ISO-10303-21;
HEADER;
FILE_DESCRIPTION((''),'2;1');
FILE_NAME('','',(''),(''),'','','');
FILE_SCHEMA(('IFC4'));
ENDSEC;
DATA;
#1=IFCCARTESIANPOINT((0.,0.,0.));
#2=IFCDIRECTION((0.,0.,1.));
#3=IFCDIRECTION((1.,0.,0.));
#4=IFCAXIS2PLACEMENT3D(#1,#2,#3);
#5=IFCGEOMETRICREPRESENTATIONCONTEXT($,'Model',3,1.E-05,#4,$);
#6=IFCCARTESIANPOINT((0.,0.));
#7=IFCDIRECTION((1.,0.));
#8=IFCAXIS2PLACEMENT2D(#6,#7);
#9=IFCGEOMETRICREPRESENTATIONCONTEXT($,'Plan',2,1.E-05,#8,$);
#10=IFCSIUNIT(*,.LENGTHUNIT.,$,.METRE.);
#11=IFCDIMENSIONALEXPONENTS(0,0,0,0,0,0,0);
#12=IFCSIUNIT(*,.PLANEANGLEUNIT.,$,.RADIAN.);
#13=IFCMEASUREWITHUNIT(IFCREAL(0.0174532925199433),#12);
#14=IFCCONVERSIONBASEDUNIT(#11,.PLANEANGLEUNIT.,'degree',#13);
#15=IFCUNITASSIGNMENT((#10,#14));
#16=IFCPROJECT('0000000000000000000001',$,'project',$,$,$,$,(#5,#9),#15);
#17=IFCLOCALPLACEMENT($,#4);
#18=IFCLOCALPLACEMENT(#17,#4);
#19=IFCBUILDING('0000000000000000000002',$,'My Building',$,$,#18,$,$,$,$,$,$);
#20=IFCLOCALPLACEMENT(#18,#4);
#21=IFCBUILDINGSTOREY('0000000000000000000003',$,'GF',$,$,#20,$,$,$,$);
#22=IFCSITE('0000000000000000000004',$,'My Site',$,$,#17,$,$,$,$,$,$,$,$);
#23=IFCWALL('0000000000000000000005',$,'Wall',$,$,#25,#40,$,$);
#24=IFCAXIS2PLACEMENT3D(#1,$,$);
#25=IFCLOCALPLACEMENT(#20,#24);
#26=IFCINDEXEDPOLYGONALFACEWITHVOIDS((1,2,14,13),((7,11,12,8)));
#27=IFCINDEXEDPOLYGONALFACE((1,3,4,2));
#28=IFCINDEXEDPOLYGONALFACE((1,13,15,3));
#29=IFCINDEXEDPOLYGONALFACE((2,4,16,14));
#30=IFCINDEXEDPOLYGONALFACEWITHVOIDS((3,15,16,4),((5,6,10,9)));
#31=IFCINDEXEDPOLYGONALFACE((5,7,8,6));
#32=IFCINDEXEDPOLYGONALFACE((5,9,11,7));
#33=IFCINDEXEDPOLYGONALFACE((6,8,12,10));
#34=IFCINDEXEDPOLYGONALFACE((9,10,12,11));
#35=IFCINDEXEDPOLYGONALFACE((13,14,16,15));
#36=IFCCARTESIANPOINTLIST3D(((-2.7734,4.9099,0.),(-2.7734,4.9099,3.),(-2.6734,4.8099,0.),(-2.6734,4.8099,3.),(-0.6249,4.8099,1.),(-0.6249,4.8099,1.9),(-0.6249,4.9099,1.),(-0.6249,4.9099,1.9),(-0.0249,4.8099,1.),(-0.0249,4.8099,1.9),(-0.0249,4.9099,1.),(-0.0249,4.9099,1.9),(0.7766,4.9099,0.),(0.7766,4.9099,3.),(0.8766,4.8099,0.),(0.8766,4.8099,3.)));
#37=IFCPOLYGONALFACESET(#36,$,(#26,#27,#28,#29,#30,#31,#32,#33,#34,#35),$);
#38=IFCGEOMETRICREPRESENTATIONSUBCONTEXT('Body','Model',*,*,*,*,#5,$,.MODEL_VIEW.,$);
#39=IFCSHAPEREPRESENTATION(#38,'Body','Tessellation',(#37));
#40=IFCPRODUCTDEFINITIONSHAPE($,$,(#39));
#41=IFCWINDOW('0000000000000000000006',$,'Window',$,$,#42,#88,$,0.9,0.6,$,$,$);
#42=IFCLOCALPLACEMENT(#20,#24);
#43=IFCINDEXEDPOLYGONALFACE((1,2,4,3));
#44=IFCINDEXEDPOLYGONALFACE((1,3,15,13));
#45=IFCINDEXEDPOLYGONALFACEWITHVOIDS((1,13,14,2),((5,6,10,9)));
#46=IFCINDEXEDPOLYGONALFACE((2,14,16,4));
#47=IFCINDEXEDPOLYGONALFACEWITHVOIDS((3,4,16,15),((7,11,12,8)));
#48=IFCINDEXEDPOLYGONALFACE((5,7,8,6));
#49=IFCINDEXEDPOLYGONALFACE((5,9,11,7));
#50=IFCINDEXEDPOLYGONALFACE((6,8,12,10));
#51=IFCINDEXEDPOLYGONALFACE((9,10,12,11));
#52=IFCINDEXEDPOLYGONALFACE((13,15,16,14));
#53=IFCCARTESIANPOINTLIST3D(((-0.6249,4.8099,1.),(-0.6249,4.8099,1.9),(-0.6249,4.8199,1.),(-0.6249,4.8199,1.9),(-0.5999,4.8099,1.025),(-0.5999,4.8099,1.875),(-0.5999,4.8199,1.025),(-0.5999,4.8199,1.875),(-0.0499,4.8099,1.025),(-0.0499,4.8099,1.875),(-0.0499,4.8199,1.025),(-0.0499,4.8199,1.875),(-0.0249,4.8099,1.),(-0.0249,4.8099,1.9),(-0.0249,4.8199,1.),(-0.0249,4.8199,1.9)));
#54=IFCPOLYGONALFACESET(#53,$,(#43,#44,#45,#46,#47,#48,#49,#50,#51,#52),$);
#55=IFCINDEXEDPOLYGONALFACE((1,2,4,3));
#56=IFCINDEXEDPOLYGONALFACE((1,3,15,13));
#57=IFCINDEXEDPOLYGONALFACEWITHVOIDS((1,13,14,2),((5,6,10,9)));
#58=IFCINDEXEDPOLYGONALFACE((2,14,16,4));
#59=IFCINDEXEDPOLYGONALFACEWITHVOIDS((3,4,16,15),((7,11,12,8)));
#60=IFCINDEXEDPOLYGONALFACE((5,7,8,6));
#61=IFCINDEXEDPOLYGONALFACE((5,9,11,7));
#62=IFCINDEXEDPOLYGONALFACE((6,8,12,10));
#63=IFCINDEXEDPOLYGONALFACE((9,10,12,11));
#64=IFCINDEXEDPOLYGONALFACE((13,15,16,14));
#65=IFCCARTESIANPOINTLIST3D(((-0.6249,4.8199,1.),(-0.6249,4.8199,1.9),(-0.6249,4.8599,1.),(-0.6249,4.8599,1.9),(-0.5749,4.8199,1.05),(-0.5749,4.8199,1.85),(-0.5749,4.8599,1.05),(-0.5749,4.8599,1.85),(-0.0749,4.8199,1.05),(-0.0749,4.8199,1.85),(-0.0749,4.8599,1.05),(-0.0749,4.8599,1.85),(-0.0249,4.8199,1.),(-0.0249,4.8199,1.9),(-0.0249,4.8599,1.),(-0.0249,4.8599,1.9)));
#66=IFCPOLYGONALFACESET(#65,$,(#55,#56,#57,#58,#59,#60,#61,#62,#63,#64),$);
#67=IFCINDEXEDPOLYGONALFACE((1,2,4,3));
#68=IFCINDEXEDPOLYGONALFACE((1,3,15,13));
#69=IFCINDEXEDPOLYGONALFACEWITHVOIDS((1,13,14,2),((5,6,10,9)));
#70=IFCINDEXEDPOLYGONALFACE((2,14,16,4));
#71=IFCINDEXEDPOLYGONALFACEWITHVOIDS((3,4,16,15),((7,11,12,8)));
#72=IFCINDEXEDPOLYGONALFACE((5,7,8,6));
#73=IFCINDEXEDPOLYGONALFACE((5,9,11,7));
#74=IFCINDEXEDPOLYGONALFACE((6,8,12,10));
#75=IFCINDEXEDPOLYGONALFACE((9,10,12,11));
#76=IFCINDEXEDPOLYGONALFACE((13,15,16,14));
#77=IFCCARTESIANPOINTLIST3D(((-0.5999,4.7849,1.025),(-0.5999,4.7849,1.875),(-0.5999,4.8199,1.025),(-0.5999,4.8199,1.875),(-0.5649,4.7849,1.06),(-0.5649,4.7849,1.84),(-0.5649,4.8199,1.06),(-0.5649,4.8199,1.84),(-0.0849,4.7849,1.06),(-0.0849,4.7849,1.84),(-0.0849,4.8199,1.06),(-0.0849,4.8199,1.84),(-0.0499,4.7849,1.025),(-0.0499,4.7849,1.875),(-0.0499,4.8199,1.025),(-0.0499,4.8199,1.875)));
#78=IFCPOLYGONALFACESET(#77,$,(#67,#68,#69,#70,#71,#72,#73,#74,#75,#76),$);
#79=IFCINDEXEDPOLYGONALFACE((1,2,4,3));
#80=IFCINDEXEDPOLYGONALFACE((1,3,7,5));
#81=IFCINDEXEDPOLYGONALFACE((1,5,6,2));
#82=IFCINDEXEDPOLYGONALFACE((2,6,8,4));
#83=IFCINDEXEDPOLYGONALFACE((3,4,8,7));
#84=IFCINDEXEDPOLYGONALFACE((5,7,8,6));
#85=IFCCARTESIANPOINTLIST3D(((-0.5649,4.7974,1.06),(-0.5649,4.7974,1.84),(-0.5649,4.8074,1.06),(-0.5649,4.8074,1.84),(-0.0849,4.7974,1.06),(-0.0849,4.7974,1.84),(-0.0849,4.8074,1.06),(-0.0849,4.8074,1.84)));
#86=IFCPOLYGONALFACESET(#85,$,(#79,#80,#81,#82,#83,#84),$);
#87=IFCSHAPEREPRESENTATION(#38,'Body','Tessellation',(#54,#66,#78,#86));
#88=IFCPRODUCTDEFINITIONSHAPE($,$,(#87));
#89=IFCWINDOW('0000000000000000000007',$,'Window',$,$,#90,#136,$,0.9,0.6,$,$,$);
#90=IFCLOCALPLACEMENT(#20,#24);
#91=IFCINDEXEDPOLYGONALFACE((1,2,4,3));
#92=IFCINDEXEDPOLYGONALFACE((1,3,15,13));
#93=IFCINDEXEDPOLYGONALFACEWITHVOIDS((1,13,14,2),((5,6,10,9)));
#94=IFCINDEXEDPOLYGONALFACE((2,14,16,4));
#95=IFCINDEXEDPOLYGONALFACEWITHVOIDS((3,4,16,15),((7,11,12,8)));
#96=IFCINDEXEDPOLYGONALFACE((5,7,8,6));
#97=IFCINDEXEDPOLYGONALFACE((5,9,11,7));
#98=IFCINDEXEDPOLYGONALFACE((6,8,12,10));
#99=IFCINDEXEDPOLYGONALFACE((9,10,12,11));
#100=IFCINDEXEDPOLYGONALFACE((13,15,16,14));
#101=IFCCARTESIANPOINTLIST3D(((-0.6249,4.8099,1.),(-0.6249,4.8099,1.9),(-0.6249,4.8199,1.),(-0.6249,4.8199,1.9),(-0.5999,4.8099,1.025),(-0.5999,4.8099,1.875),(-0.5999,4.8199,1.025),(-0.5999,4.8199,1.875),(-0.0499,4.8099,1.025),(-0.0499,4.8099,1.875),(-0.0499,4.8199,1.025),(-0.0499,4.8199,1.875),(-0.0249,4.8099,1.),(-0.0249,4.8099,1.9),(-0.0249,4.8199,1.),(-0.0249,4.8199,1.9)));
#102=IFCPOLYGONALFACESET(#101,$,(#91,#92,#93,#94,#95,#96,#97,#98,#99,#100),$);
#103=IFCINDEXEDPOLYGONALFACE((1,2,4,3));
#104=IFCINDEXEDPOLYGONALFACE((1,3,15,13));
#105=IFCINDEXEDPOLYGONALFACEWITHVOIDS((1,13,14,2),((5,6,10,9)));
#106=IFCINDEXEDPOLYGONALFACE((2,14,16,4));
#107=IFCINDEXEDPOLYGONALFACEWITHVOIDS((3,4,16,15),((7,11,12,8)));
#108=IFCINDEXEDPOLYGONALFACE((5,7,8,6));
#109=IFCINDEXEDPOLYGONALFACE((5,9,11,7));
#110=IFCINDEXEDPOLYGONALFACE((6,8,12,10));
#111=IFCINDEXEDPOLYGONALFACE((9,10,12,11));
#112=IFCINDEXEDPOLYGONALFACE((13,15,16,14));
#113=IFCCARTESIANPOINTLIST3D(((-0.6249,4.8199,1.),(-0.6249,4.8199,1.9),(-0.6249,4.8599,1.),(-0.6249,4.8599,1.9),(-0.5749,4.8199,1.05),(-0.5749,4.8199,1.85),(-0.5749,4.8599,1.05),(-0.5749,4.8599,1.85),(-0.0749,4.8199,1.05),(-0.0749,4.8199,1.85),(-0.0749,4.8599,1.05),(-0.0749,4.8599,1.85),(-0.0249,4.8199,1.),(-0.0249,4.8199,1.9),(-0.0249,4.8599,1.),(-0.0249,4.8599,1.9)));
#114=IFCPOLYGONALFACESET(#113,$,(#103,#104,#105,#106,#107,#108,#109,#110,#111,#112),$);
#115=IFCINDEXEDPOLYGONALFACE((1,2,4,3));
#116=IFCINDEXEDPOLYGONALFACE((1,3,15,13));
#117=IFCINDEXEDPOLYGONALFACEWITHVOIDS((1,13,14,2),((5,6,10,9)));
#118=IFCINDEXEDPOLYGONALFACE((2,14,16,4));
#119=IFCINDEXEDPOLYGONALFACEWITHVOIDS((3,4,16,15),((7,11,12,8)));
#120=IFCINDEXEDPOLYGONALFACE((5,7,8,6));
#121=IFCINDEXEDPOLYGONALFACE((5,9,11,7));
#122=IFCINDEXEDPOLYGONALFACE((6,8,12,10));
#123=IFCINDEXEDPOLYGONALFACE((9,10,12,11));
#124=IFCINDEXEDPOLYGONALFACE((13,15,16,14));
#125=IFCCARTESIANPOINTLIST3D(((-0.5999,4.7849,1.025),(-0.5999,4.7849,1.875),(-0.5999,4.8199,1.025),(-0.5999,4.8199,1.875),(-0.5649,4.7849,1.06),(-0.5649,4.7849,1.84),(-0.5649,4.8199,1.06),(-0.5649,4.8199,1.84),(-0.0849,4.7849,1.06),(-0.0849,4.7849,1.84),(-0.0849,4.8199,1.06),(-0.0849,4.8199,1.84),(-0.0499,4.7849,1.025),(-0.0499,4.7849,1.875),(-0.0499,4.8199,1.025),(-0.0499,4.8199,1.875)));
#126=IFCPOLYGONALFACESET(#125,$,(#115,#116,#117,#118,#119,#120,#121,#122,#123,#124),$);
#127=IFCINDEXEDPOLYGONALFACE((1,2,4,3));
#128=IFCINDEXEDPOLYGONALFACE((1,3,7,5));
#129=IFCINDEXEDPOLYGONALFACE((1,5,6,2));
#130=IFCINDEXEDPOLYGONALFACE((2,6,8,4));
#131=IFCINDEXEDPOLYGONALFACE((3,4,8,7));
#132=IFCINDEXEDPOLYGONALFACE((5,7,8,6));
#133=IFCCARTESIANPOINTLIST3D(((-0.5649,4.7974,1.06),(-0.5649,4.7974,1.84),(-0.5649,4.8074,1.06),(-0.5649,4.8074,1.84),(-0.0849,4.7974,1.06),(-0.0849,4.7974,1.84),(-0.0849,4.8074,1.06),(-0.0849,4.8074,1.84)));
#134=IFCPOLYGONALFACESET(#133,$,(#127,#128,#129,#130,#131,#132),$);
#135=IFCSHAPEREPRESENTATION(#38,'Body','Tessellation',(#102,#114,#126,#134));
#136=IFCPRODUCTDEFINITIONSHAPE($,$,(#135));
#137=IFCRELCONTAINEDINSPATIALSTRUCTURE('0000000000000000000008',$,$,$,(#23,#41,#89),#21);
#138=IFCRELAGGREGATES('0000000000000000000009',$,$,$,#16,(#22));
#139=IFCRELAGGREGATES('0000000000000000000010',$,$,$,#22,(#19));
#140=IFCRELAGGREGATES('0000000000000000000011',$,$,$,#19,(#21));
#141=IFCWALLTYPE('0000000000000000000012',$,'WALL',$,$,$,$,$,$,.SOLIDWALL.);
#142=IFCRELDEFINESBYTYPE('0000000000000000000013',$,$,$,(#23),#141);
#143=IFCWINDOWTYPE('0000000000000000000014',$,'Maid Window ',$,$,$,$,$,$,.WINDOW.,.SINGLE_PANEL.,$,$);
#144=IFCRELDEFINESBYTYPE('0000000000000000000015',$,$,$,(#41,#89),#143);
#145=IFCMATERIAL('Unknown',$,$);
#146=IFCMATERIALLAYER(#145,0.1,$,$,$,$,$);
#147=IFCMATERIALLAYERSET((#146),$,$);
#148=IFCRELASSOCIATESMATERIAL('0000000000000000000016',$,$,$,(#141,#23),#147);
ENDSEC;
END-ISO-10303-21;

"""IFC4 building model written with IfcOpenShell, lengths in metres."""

from ifc_helpers import new_model, entity, si_unit, converted_unit, frame, origin_with_axes, origin_2d_with_axis, place, context, subcontext, project, spatial, line, indexed_curve, outline, extrude, shape, source, transform, mapped, material, layer, layer_set, layer_usage, type_object, type_shapes, element, fill, save


model = new_model("IFC4")

# Units and contexts
model_context = context("Model", 3, precision=1e-05, world=origin_with_axes())
plan_context = context("Plan", 2, precision=1e-05, world=origin_2d_with_axis())
body_context_1 = subcontext(model_context, "Body", "Model", "MODEL_VIEW")
body_context_2 = subcontext(plan_context, "Body", "Plan", "PLAN_VIEW")
ifc_project = project(units=[si_unit("LENGTHUNIT", "METRE"), converted_unit("PLANEANGLEUNIT", "degree", entity("IfcReal", 0.0174532925199433), si_unit("PLANEANGLEUNIT", "RADIAN"), dimensions=[0, 0, 0, 0, 0, 0, 0])], contexts=[model_context, plan_context])

# Site, building, storey
site_placement = place(None, origin_with_axes())
site = spatial("IfcSite", under=ifc_project, at=site_placement, Name="My Site")
building_placement = place(site_placement, origin_with_axes())
building = spatial("IfcBuilding", under=site, at=building_placement, Name="My Building")
storey_placement = place(building_placement, origin_with_axes())
storey = spatial("IfcBuildingStorey", under=building, at=storey_placement, Name="GF")

# Shared definitions
ifc_material = material(Name="Unknown")

# Shared definitions
ifc_layer = layer(ifc_material, 0.1)
ifc_layer_set = layer_set([ifc_layer])
wall_type = type_object("IfcWallType", Name="WALL", PredefinedType="SOLIDWALL", material=ifc_layer_set)

# Wall, openings, windows
ifc_layer_usage_1 = layer_usage(ifc_layer_set, "AXIS2", "POSITIVE", 0.0)
wall_1_placement = place(storey_placement, frame((0.7766, 4.9099, 0.0), z_axis=(0.0, 0.0, 1.0), x_axis=(-1.0, 0.0, 0.0)))
wall_1 = element("IfcWall", 1, at=wall_1_placement, inside=storey, type_object=wall_type, material=ifc_layer_usage_1, Name="Wall", context=body_context_1, shape_type="SweptSolid", body=[
    extrude(outline(indexed_curve([(0.0, 0.0), (-0.1, 0.1), (3.45, 0.1), (3.55, 0.0)], segments=[line(1, 2, 3, 4, 1)])), origin_with_axes(), (0.0, 0.0, 1.0), 3.0),
])
shared_shape_1 = source(origin_with_axes(), body_context_1, "Body", "SweptSolid", [
    extrude(outline(indexed_curve([(0.0, 0.0), (0.6, 0.0), (0.6, 0.9), (0.0, 0.9)], segments=[line(1, 2, 3, 4, 1)])), frame((0.0, -0.6, 0.0), z_axis=(0.0, -1.0, 0.0), x_axis=(1.0, 0.0, 0.0)), (0.0, 0.0, -1.0), 1.2),
])
opening_1_placement = place(wall_1_placement, frame((0.8015, 0.0, 1.0), z_axis=(0.0, 0.0, 1.0), x_axis=(1.0, 0.0, 0.0)))
opening_1 = element("IfcOpeningElement", 2, at=opening_1_placement, cuts=wall_1, PredefinedType="OPENING", context=body_context_1, shape_type="MappedRepresentation", body=[
    mapped(shared_shape_1, transform((0.0, 0.0, 0.0), x_axis=(1.0, 0.0, 0.0), y_axis=(0.0, 1.0, 0.0), z_axis=(0.0, 0.0, 1.0), scale=1.0)),
])
opening_2_placement = place(wall_1_placement, frame((0.8015, 0.0, 1.0), z_axis=(0.0, 0.0, 1.0), x_axis=(1.0, 0.0, 0.0)))
opening_2 = element("IfcOpeningElement", 3, at=opening_2_placement, cuts=wall_1, PredefinedType="OPENING", context=body_context_1, shape_type="MappedRepresentation", body=[
    mapped(shared_shape_1, transform((0.0, 0.0, 0.0), x_axis=(1.0, 0.0, 0.0), y_axis=(0.0, 1.0, 0.0), z_axis=(0.0, 0.0, 1.0), scale=1.0)),
])
window_type_1 = type_object("IfcWindowType", Name="Maid Window ", PartitioningType="SINGLE_PANEL", PredefinedType="WINDOW")
shared_shape_2 = source(origin_with_axes(), body_context_1, "Body", "SweptSolid", [
    extrude(outline(indexed_curve([(0.0, 0.0), (0.6, 0.0), (0.6, 0.9), (0.0, 0.9)], segments=[line(1, 2, 3, 4, 1)]), holes=[indexed_curve([(0.025, 0.025), (0.575, 0.025), (0.575, 0.875), (0.025, 0.875)], segments=[line(1, 2, 3, 4, 1)])]), frame((0.0, 0.09, 0.0), z_axis=(0.0, -1.0, 0.0), x_axis=(1.0, 0.0, 0.0)), (0.0, 0.0, -1.0), 0.01),
    extrude(outline(indexed_curve([(0.0, 0.0), (0.6, 0.0), (0.6, 0.9), (0.0, 0.9)], segments=[line(1, 2, 3, 4, 1)]), holes=[indexed_curve([(0.05, 0.05), (0.55, 0.05), (0.55, 0.85), (0.05, 0.85)], segments=[line(1, 2, 3, 4, 1)])]), frame((0.0, 0.05, 0.0), z_axis=(0.0, -1.0, 0.0), x_axis=(1.0, 0.0, 0.0)), (0.0, 0.0, -1.0), 0.04),
    extrude(outline(indexed_curve([(0.0, 0.0), (0.55, 0.0), (0.55, 0.85), (0.0, 0.85)], segments=[line(1, 2, 3, 4, 1)]), holes=[indexed_curve([(0.035, 0.035), (0.515, 0.035), (0.515, 0.815), (0.035, 0.815)], segments=[line(1, 2, 3, 4, 1)])]), frame((0.025, 0.09, 0.025), z_axis=(0.0, -1.0, 0.0), x_axis=(1.0, 0.0, 0.0)), (0.0, 0.0, -1.0), 0.035),
    extrude(outline(indexed_curve([(0.035, 0.035), (0.515, 0.035), (0.515, 0.815), (0.035, 0.815)], segments=[line(1, 2, 3, 4, 1)])), frame((0.025, 0.1025, 0.025), z_axis=(0.0, -1.0, 0.0), x_axis=(1.0, 0.0, 0.0)), (0.0, 0.0, -1.0), 0.01),
])
shared_shape_3 = source(origin_with_axes(), body_context_2, "Body", "Curve2D", [
    entity("IfcIndexedPolyCurve", entity("IfcCartesianPointList2D", [[0.05, 0.05], [0.55, 0.05]])),
    entity("IfcIndexedPolyCurve", entity("IfcCartesianPointList2D", [[0.0, 0.1], [0.025, 0.1], [0.025, 0.09], [0.05, 0.09], [0.05, 0.05], [0.0, 0.05]]), [entity("IfcLineIndex", [1, 2, 3, 4, 5, 6, 1])]),
    entity("IfcIndexedPolyCurve", entity("IfcCartesianPointList2D", [[0.6, 0.1], [0.575, 0.1], [0.575, 0.09], [0.55, 0.09], [0.55, 0.05], [0.6, 0.05]]), [entity("IfcLineIndex", [1, 2, 3, 4, 5, 6, 1])]),
    entity("IfcIndexedPolyCurve", entity("IfcCartesianPointList2D", [[0.025, 0.09], [0.06, 0.09], [0.06, 0.125], [0.025, 0.125]]), [entity("IfcLineIndex", [1, 2, 3, 4, 1])]),
    entity("IfcIndexedPolyCurve", entity("IfcCartesianPointList2D", [[0.575, 0.09], [0.54, 0.09], [0.54, 0.125], [0.575, 0.125]]), [entity("IfcLineIndex", [1, 2, 3, 4, 1])]),
    entity("IfcIndexedPolyCurve", entity("IfcCartesianPointList2D", [[0.06, 0.09], [0.54, 0.09]])),
    entity("IfcIndexedPolyCurve", entity("IfcCartesianPointList2D", [[0.06, 0.125], [0.54, 0.125]])),
    entity("IfcIndexedPolyCurve", entity("IfcCartesianPointList2D", [[0.06, 0.1075], [0.54, 0.1075]])),
])
type_shapes(window_type_1, [shared_shape_2, shared_shape_3])
window_1_placement = place(opening_1_placement, frame((0.0, 0.0, 0.0), z_axis=(0.0, 0.0, 1.0), x_axis=(1.0, 0.0, 0.0)))
window_1 = element("IfcWindow", 4, at=window_1_placement, inside=storey, type_object=window_type_1, Name="Window", OverallHeight=0.9, OverallWidth=0.6, shapes=[
    shape(body_context_1, "Body", "MappedRepresentation", [mapped(shared_shape_2, transform((0.0, 0.0, 0.0), x_axis=(1.0, 0.0, 0.0), y_axis=(0.0, 1.0, 0.0), z_axis=(0.0, 0.0, 1.0), scale=1.0))]),
    shape(body_context_2, "Body", "MappedRepresentation", [mapped(shared_shape_3, transform((0.0, 0.0, 0.0), x_axis=(1.0, 0.0, 0.0), y_axis=(0.0, 1.0, 0.0), z_axis=(0.0, 0.0, 1.0), scale=1.0))]),
])
fill(opening_1, window_1)
window_2_placement = place(opening_2_placement, frame((0.0, 0.0, 0.0), z_axis=(0.0, 0.0, 1.0), x_axis=(1.0, 0.0, 0.0)))
window_2 = element("IfcWindow", 5, at=window_2_placement, inside=storey, type_object=window_type_1, Name="Window", OverallHeight=0.9, OverallWidth=0.6, shapes=[
    shape(body_context_1, "Body", "MappedRepresentation", [mapped(shared_shape_2, transform((0.0, 0.0, 0.0), x_axis=(1.0, 0.0, 0.0), y_axis=(0.0, 1.0, 0.0), z_axis=(0.0, 0.0, 1.0), scale=1.0))]),
    shape(body_context_2, "Body", "MappedRepresentation", [mapped(shared_shape_3, transform((0.0, 0.0, 0.0), x_axis=(1.0, 0.0, 0.0), y_axis=(0.0, 1.0, 0.0), z_axis=(0.0, 0.0, 1.0), scale=1.0))]),
])
fill(opening_2, window_2)

save(model, "model.ifc")
